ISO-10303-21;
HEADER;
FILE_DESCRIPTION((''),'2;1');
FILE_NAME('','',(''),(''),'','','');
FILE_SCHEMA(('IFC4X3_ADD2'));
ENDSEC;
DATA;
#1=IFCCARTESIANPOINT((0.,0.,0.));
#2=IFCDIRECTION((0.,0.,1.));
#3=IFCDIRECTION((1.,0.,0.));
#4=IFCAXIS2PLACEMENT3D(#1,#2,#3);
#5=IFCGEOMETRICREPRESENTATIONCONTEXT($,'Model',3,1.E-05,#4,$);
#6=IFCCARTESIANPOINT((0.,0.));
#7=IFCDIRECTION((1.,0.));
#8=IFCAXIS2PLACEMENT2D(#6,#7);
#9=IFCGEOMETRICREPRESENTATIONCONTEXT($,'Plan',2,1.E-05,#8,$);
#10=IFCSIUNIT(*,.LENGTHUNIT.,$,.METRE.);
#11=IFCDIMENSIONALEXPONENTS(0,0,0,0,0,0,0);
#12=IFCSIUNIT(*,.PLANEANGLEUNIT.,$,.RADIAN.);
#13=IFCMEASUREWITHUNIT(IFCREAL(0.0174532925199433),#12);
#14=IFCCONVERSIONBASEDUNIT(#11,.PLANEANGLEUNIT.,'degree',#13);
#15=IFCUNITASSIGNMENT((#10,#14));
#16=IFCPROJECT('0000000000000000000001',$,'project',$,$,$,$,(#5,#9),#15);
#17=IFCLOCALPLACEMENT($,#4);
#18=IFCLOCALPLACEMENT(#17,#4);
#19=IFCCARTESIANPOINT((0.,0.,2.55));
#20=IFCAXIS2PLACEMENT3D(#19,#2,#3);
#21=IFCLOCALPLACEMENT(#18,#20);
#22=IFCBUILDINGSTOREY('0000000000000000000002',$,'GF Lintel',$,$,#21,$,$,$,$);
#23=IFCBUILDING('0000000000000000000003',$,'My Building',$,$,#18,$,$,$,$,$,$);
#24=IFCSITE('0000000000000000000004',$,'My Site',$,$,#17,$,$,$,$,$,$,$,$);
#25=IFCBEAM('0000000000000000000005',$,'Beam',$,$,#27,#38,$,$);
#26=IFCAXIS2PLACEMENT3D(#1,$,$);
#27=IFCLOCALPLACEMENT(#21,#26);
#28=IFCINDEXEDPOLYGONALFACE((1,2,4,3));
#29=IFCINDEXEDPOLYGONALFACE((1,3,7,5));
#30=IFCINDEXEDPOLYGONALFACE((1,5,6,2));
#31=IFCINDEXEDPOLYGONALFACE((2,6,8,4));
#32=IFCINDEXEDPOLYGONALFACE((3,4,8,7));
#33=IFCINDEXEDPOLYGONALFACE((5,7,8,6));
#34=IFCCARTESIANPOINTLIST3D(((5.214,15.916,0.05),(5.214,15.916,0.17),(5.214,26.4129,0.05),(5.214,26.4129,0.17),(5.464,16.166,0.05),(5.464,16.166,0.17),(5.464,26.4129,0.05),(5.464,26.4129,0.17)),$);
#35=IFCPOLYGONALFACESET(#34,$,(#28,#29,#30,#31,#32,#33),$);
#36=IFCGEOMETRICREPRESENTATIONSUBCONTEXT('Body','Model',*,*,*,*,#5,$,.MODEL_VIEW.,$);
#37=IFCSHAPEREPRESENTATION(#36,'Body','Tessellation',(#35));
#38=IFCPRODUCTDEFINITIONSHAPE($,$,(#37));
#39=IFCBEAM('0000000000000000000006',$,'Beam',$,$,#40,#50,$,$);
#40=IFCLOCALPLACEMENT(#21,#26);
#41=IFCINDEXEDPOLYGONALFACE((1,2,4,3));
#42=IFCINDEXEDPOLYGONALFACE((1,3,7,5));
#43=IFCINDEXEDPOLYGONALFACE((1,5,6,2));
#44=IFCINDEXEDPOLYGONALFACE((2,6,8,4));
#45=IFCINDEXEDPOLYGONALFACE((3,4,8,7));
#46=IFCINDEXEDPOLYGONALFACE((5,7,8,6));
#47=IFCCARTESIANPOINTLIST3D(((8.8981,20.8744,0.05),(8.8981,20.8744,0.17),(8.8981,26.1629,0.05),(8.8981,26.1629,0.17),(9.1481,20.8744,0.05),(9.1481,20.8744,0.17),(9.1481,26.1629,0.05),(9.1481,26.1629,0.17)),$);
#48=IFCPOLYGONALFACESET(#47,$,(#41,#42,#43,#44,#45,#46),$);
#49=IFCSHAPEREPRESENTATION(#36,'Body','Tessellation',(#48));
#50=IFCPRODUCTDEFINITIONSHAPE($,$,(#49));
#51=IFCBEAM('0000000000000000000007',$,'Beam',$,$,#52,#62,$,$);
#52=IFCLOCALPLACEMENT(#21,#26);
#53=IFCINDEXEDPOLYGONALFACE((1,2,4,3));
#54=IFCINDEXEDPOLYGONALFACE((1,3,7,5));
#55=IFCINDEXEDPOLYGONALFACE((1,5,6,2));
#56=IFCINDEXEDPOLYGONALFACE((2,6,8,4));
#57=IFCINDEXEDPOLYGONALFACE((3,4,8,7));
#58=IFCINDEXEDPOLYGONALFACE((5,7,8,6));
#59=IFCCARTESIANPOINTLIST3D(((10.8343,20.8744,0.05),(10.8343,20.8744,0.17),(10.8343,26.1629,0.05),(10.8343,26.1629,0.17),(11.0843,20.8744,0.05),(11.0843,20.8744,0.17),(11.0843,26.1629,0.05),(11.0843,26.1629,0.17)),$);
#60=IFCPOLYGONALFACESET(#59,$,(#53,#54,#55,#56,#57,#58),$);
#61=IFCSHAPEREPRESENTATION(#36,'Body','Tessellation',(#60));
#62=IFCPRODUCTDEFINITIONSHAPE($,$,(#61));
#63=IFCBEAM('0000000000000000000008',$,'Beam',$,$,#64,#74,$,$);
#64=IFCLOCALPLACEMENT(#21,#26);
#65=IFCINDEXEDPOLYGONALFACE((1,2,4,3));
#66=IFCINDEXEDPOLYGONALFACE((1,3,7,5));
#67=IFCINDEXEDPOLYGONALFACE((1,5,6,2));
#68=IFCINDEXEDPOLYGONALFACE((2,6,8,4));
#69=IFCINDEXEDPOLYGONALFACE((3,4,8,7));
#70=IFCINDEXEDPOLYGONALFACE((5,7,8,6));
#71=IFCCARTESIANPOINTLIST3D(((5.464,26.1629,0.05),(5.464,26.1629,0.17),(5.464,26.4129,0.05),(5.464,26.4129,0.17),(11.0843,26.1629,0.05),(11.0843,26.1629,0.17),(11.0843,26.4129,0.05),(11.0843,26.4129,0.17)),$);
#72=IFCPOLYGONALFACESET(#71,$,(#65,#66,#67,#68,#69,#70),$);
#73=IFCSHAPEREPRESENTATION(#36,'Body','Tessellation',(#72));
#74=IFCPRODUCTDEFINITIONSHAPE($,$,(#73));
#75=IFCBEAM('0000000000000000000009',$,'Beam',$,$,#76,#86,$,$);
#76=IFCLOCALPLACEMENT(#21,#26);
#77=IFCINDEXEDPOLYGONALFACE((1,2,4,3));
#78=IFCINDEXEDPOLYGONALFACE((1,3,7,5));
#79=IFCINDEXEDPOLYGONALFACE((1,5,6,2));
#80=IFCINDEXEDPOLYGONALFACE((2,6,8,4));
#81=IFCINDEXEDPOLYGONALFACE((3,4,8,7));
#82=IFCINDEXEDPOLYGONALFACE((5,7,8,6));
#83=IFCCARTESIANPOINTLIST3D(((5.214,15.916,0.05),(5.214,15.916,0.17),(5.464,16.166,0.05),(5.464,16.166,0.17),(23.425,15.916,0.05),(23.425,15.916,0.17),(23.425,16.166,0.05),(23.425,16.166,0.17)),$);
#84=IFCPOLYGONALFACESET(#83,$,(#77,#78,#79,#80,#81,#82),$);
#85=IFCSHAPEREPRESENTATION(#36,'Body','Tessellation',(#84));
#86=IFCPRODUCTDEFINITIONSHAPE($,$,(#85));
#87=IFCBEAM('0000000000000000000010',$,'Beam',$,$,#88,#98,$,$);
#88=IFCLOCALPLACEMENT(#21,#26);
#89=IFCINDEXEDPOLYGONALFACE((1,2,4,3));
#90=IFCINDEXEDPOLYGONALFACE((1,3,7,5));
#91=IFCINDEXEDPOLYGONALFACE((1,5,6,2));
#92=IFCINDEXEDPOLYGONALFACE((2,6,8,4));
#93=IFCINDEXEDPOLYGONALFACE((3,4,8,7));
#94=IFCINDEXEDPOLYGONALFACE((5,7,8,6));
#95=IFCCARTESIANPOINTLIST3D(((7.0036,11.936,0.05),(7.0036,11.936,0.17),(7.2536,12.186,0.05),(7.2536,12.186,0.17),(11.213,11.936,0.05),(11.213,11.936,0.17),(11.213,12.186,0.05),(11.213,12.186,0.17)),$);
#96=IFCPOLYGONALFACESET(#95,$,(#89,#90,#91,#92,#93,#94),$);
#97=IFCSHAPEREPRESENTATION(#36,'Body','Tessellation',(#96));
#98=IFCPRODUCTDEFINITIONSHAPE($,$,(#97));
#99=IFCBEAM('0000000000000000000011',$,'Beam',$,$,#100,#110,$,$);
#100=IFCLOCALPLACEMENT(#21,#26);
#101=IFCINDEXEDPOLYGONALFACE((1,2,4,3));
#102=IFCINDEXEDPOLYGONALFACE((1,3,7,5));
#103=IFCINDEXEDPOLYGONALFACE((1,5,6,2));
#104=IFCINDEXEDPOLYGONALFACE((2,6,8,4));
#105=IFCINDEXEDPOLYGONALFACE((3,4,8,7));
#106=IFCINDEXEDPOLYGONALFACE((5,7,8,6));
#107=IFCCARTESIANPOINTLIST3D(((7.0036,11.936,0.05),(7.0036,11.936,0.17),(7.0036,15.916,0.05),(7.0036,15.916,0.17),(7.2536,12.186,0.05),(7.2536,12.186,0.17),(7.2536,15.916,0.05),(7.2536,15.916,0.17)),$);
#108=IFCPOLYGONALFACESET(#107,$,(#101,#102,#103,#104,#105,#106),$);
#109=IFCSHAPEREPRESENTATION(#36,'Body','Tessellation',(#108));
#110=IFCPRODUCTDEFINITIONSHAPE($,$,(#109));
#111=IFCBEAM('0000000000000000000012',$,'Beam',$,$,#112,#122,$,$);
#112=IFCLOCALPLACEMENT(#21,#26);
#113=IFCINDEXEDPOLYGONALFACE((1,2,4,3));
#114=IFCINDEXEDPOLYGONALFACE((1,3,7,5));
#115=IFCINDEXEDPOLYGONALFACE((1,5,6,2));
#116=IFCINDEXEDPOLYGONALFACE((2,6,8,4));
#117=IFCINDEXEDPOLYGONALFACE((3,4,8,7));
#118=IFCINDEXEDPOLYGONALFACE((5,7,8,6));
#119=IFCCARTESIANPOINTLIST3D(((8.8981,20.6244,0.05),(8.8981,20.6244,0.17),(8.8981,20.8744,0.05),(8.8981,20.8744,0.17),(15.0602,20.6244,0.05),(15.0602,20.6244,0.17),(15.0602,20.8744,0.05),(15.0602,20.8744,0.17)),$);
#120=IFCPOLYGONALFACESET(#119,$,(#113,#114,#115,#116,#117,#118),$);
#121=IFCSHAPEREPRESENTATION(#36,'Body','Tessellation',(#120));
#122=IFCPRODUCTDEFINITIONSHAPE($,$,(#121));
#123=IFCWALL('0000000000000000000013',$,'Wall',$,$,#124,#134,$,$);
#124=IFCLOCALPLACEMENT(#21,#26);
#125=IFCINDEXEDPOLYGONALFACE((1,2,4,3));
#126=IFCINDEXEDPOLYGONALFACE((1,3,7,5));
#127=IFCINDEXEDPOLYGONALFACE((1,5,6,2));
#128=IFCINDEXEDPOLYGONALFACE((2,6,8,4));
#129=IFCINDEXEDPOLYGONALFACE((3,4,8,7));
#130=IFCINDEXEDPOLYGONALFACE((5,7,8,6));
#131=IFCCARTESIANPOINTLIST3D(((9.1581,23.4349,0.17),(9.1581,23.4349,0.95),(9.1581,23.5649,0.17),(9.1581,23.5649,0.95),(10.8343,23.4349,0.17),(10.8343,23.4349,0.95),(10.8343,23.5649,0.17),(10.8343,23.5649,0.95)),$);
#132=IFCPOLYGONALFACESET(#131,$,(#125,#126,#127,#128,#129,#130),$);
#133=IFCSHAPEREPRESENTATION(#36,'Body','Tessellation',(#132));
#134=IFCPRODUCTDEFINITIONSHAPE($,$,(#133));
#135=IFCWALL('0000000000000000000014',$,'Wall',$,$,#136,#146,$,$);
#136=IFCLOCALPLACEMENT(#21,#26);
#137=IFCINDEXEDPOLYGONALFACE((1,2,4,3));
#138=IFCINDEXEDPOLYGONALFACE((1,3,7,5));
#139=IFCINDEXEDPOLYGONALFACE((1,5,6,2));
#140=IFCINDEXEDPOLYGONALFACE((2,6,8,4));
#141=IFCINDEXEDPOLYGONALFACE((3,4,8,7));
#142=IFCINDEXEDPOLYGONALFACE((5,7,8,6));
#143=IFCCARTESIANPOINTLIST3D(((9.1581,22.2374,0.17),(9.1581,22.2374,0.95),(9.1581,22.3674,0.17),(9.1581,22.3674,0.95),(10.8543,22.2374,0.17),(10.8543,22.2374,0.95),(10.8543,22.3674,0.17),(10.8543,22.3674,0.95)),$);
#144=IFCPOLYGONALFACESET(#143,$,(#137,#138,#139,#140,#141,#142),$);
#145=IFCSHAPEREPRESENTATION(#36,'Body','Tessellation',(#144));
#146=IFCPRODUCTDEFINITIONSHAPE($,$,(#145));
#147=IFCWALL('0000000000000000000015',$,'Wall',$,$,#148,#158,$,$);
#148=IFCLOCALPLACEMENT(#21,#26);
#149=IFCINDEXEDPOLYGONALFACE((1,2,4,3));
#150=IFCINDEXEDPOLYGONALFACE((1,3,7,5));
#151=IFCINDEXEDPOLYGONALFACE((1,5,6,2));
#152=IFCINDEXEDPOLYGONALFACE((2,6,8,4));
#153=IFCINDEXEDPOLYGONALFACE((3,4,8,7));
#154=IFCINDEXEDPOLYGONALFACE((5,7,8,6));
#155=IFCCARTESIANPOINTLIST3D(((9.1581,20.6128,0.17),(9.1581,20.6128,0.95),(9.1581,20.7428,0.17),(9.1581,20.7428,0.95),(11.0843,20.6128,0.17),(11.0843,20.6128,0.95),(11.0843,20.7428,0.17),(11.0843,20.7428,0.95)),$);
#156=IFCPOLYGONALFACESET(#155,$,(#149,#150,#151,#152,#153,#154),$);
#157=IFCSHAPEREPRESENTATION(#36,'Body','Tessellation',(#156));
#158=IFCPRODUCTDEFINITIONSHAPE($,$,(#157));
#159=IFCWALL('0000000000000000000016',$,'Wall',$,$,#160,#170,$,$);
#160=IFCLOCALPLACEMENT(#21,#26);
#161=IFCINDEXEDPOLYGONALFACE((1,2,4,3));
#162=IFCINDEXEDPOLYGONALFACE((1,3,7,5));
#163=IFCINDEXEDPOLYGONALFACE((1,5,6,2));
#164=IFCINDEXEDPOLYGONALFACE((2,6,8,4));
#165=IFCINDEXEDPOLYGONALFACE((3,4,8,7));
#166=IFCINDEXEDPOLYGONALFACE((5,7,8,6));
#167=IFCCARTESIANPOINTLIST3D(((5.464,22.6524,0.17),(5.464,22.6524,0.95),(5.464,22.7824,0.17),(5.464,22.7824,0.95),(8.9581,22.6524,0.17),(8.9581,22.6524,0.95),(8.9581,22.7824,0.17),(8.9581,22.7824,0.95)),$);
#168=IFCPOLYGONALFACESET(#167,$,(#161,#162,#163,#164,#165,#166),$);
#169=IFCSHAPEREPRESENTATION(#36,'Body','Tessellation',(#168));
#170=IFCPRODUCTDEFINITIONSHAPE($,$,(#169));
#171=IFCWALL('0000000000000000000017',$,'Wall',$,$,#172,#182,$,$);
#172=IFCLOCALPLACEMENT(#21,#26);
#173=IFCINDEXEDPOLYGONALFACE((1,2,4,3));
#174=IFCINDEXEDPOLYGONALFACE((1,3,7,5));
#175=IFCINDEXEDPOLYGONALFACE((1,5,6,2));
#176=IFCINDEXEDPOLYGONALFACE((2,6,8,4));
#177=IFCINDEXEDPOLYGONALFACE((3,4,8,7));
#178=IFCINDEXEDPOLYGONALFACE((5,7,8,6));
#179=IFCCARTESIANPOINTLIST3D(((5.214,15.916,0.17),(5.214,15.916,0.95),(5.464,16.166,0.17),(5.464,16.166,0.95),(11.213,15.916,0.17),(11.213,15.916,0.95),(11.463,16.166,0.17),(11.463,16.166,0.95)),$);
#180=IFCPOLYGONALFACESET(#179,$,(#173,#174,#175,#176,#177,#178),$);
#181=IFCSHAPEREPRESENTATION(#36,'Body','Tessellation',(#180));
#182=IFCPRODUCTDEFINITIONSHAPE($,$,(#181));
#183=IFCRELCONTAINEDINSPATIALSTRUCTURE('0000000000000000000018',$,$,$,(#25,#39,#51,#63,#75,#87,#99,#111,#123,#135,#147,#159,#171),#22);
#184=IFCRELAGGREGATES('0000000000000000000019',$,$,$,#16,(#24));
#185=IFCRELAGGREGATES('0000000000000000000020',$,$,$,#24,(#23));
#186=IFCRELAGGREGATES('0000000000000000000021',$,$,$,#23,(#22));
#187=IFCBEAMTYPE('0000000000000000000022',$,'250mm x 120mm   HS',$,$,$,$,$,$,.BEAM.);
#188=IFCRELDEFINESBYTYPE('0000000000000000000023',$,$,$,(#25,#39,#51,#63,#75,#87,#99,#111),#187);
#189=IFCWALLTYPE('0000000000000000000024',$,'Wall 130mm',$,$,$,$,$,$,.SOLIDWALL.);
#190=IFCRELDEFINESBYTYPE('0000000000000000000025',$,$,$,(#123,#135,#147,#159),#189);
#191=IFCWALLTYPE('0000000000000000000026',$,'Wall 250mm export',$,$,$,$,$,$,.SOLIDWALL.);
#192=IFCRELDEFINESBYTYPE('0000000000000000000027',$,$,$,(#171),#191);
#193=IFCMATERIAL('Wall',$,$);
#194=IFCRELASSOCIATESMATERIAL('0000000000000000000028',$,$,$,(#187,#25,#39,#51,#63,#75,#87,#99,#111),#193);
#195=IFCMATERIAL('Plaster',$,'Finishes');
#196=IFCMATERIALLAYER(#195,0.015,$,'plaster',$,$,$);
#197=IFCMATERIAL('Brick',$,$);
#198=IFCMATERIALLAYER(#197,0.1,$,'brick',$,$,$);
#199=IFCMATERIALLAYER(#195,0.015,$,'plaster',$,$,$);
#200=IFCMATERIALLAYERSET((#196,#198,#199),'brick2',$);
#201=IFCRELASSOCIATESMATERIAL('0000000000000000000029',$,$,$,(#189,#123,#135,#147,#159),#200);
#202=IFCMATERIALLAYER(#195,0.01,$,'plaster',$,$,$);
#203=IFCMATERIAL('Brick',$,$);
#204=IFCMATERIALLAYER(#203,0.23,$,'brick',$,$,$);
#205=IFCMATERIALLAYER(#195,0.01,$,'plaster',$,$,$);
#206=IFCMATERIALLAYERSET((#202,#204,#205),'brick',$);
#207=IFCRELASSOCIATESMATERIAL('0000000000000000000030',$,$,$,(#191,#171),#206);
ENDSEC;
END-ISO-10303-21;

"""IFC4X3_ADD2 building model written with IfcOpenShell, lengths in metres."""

from ifc_helpers import new_model, entity, si_unit, converted_unit, frame, origin_with_axes, origin_2d_with_axis, place, context, subcontext, project, spatial, line, indexed_curve, rectangle, outline, extrude, clip, halfspace, material, layer, layer_set, layer_usage, material_profile, profile_set, profile_usage, type_object, element, save


model = new_model("IFC4X3_ADD2")

# Units and contexts
model_context = context("Model", 3, precision=1e-05, world=origin_with_axes())
plan_context = context("Plan", 2, precision=1e-05, world=origin_2d_with_axis())
body_context = subcontext(model_context, "Body", "Model", "MODEL_VIEW")
ifc_project = project(units=[si_unit("LENGTHUNIT", "METRE"), converted_unit("PLANEANGLEUNIT", "degree", entity("IfcReal", 0.0174532925199433), si_unit("PLANEANGLEUNIT", "RADIAN"), dimensions=[0, 0, 0, 0, 0, 0, 0])], contexts=[model_context, plan_context])

# Site, building, storey
site_placement = place(None, origin_with_axes())
site = spatial("IfcSite", under=ifc_project, at=site_placement, Name="My Site")
building_placement = place(site_placement, origin_with_axes())
building = spatial("IfcBuilding", under=site, at=building_placement, Name="My Building")
storey_placement = place(building_placement, frame((0.0, 0.0, 2.55), z_axis=(0.0, 0.0, 1.0), x_axis=(1.0, 0.0, 0.0)))
storey = spatial("IfcBuildingStorey", under=building, at=storey_placement, Name="GF Lintel")

# Beams
ifc_material_1 = material(Name="Wall")
ifc_material_profile = material_profile(ifc_material_1, rectangle(XDim=0.25, YDim=0.12))
ifc_profile_set = profile_set([ifc_material_profile], Name="concrete")
ifc_profile_usage_1 = profile_usage(ifc_profile_set, cardinal=5)
beam_type = type_object("IfcBeamType", Name="250mm x 120mm   HS", PredefinedType="BEAM", material=ifc_profile_set)
beam_1_placement = place(storey_placement, frame((5.339, 26.4129, 0.11), z_axis=(0.0, -1.0, 0.0), x_axis=(1.0, 0.0, 0.0)))
element("IfcBeam", 1, at=beam_1_placement, inside=storey, type_object=beam_type, material=ifc_profile_usage_1, Name="Beam", context=body_context, shape_type="Clipping", body=[
    clip(extrude(rectangle(XDim=0.25, YDim=0.12), origin_with_axes(), (0.0, 0.0, 1.0), 10.4969), halfspace(frame((-0.125, -2.66, 10.4969), z_axis=(0.707107, 0.0, 0.707107), x_axis=(0.0, -1.0, 0.0)), False)),
])
ifc_profile_usage_2 = profile_usage(ifc_profile_set, cardinal=5)
beam_2_placement = place(storey_placement, frame((9.0231, 26.1629, 0.11), z_axis=(0.0, -1.0, 0.0), x_axis=(1.0, 0.0, 0.0)))
element("IfcBeam", 2, at=beam_2_placement, inside=storey, type_object=beam_type, material=ifc_profile_usage_2, Name="Beam", context=body_context, shape_type="SweptSolid", body=[
    extrude(rectangle(XDim=0.25, YDim=0.12), origin_with_axes(), (0.0, 0.0, 1.0), 5.2885),
])
ifc_profile_usage_3 = profile_usage(ifc_profile_set, cardinal=5)
beam_3_placement = place(storey_placement, frame((10.9593, 26.1629, 0.11), z_axis=(0.0, -1.0, 0.0), x_axis=(1.0, 0.0, 0.0)))
element("IfcBeam", 3, at=beam_3_placement, inside=storey, type_object=beam_type, material=ifc_profile_usage_3, Name="Beam", context=body_context, shape_type="SweptSolid", body=[
    extrude(rectangle(XDim=0.25, YDim=0.12), origin_with_axes(), (0.0, 0.0, 1.0), 5.2885),
])
ifc_profile_usage_4 = profile_usage(ifc_profile_set, cardinal=5)
beam_4_placement = place(storey_placement, frame((5.464, 26.2879, 0.11), z_axis=(1.0, 0.0, 0.0), x_axis=(0.0, 1.0, 0.0)))
element("IfcBeam", 4, at=beam_4_placement, inside=storey, type_object=beam_type, material=ifc_profile_usage_4, Name="Beam", context=body_context, shape_type="SweptSolid", body=[
    extrude(rectangle(XDim=0.25, YDim=0.12), origin_with_axes(), (0.0, 0.0, 1.0), 5.6203),
])
ifc_profile_usage_5 = profile_usage(ifc_profile_set, cardinal=5)
beam_5_placement = place(storey_placement, frame((5.214, 16.041, 0.11), z_axis=(1.0, 0.0, 0.0), x_axis=(0.0, 1.0, 0.0)))
element("IfcBeam", 5, at=beam_5_placement, inside=storey, type_object=beam_type, material=ifc_profile_usage_5, Name="Beam", context=body_context, shape_type="Clipping", body=[
    clip(extrude(rectangle(XDim=0.25, YDim=0.12), origin_with_axes(), (0.0, 0.0, 1.0), 18.211), halfspace(frame((-0.125, -2.66, 0.0), z_axis=(0.707107, 0.0, -0.707107), x_axis=(0.0, -1.0, 0.0)), False)),
])
ifc_profile_usage_6 = profile_usage(ifc_profile_set, cardinal=5)
beam_6_placement = place(storey_placement, frame((7.0036, 12.061, 0.11), z_axis=(1.0, 0.0, 0.0), x_axis=(0.0, 1.0, 0.0)))
element("IfcBeam", 6, at=beam_6_placement, inside=storey, type_object=beam_type, material=ifc_profile_usage_6, Name="Beam", context=body_context, shape_type="Clipping", body=[
    clip(extrude(rectangle(XDim=0.25, YDim=0.12), origin_with_axes(), (0.0, 0.0, 1.0), 4.2094), halfspace(frame((-0.125, -2.66, 0.0), z_axis=(0.707107, 0.0, -0.707107), x_axis=(0.0, -1.0, 0.0)), False)),
])
ifc_profile_usage_7 = profile_usage(ifc_profile_set, cardinal=5)
beam_7_placement = place(storey_placement, frame((7.1286, 15.916, 0.11), z_axis=(0.0, -1.0, 0.0), x_axis=(1.0, 0.0, 0.0)))
element("IfcBeam", 7, at=beam_7_placement, inside=storey, type_object=beam_type, material=ifc_profile_usage_7, Name="Beam", context=body_context, shape_type="Clipping", body=[
    clip(extrude(rectangle(XDim=0.25, YDim=0.12), origin_with_axes(), (0.0, 0.0, 1.0), 3.98), halfspace(frame((-0.125, -2.66, 3.98), z_axis=(0.707107, 0.0, 0.707107), x_axis=(0.0, -1.0, 0.0)), False)),
])
ifc_profile_usage_8 = profile_usage(ifc_profile_set, cardinal=5)
beam_8_placement = place(storey_placement, frame((8.8981, 20.7494, 0.11), z_axis=(1.0, 0.0, 0.0), x_axis=(0.0, 1.0, 0.0)))
element("IfcBeam", 8, at=beam_8_placement, inside=storey, type_object=beam_type, material=ifc_profile_usage_8, Name="Beam", context=body_context, shape_type="SweptSolid", body=[
    extrude(rectangle(XDim=0.25, YDim=0.12), origin_with_axes(), (0.0, 0.0, 1.0), 6.1621),
])

# Walls
ifc_material_2 = material(Name="Plaster", Category="Finishes")
ifc_layer_1 = layer(ifc_material_2, 0.015, Name="plaster")
ifc_material_3 = material(Name="Brick")
ifc_layer_2 = layer(ifc_material_3, 0.1, Name="brick")
ifc_layer_3 = layer(ifc_material_2, 0.015, Name="plaster")
ifc_layer_set_1 = layer_set([ifc_layer_1, ifc_layer_2, ifc_layer_3], Name="brick2")
ifc_layer_usage_1 = layer_usage(ifc_layer_set_1, "AXIS2", "POSITIVE", 0.0)
wall_type_1 = type_object("IfcWallType", Name="Wall 130mm", PredefinedType="SOLIDWALL", material=ifc_layer_set_1)
wall_1_placement = place(storey_placement, frame((9.1581, 23.4349, 0.17), z_axis=(0.0, 0.0, 1.0), x_axis=(1.0, 0.0, 0.0)))
element("IfcWall", 9, at=wall_1_placement, inside=storey, type_object=wall_type_1, material=ifc_layer_usage_1, Name="Wall", context=body_context, shape_type="SweptSolid", body=[
    extrude(outline(indexed_curve([(0.0, 0.0), (0.0, 0.13), (1.6762, 0.13), (1.6762, 0.0)], segments=[line(1, 2, 3, 4, 1)])), origin_with_axes(), (0.0, 0.0, 1.0), 0.78),
])
ifc_layer_usage_2 = layer_usage(ifc_layer_set_1, "AXIS2", "POSITIVE", 0.0)
wall_2_placement = place(storey_placement, frame((9.1581, 22.2374, 0.17), z_axis=(0.0, 0.0, 1.0), x_axis=(1.0, 0.0, 0.0)))
element("IfcWall", 10, at=wall_2_placement, inside=storey, type_object=wall_type_1, material=ifc_layer_usage_2, Name="Wall", context=body_context, shape_type="SweptSolid", body=[
    extrude(outline(indexed_curve([(0.0, 0.0), (0.0, 0.13), (1.6962, 0.13), (1.6962, 0.0)], segments=[line(1, 2, 3, 4, 1)])), origin_with_axes(), (0.0, 0.0, 1.0), 0.78),
])
ifc_layer_usage_3 = layer_usage(ifc_layer_set_1, "AXIS2", "POSITIVE", 0.0)
wall_3_placement = place(storey_placement, frame((9.1581, 20.6128, 0.17), z_axis=(0.0, 0.0, 1.0), x_axis=(1.0, 0.0, 0.0)))
element("IfcWall", 11, at=wall_3_placement, inside=storey, type_object=wall_type_1, material=ifc_layer_usage_3, Name="Wall", context=body_context, shape_type="SweptSolid", body=[
    extrude(outline(indexed_curve([(0.0, 0.0), (0.0, 0.13), (1.9262, 0.13), (1.9262, 0.0)], segments=[line(1, 2, 3, 4, 1)])), origin_with_axes(), (0.0, 0.0, 1.0), 0.78),
])
ifc_layer_usage_4 = layer_usage(ifc_layer_set_1, "AXIS2", "POSITIVE", 0.0)
wall_4_placement = place(storey_placement, frame((5.464, 22.6524, 0.17), z_axis=(0.0, 0.0, 1.0), x_axis=(1.0, 0.0, 0.0)))
element("IfcWall", 12, at=wall_4_placement, inside=storey, type_object=wall_type_1, material=ifc_layer_usage_4, Name="Wall", context=body_context, shape_type="SweptSolid", body=[
    extrude(outline(indexed_curve([(0.0, 0.0), (0.0, 0.13), (3.4941, 0.13), (3.4941, 0.0)], segments=[line(1, 2, 3, 4, 1)])), origin_with_axes(), (0.0, 0.0, 1.0), 0.78),
])
ifc_layer_4 = layer(ifc_material_2, 0.01, Name="plaster")
ifc_material_4 = material(Name="Brick")
ifc_layer_5 = layer(ifc_material_4, 0.23, Name="brick")
ifc_layer_6 = layer(ifc_material_2, 0.01, Name="plaster")
ifc_layer_set_2 = layer_set([ifc_layer_4, ifc_layer_5, ifc_layer_6], Name="brick")
ifc_layer_usage_5 = layer_usage(ifc_layer_set_2, "AXIS2", "POSITIVE", 0.0)
wall_type_2 = type_object("IfcWallType", Name="Wall 250mm export", PredefinedType="SOLIDWALL", material=ifc_layer_set_2)
wall_5_placement = place(storey_placement, frame((5.464, 15.916, 0.17), z_axis=(0.0, 0.0, 1.0), x_axis=(1.0, 0.0, 0.0)))
element("IfcWall", 13, at=wall_5_placement, inside=storey, type_object=wall_type_2, material=ifc_layer_usage_5, Name="Wall", context=body_context, shape_type="SweptSolid", body=[
    extrude(outline(indexed_curve([(-0.25, 0.0), (0.0, 0.25), (5.999, 0.25), (5.749, 0.0)], segments=[line(1, 2, 3, 4, 1)])), origin_with_axes(), (0.0, 0.0, 1.0), 0.78),
])

save(model, "model.ifc")
